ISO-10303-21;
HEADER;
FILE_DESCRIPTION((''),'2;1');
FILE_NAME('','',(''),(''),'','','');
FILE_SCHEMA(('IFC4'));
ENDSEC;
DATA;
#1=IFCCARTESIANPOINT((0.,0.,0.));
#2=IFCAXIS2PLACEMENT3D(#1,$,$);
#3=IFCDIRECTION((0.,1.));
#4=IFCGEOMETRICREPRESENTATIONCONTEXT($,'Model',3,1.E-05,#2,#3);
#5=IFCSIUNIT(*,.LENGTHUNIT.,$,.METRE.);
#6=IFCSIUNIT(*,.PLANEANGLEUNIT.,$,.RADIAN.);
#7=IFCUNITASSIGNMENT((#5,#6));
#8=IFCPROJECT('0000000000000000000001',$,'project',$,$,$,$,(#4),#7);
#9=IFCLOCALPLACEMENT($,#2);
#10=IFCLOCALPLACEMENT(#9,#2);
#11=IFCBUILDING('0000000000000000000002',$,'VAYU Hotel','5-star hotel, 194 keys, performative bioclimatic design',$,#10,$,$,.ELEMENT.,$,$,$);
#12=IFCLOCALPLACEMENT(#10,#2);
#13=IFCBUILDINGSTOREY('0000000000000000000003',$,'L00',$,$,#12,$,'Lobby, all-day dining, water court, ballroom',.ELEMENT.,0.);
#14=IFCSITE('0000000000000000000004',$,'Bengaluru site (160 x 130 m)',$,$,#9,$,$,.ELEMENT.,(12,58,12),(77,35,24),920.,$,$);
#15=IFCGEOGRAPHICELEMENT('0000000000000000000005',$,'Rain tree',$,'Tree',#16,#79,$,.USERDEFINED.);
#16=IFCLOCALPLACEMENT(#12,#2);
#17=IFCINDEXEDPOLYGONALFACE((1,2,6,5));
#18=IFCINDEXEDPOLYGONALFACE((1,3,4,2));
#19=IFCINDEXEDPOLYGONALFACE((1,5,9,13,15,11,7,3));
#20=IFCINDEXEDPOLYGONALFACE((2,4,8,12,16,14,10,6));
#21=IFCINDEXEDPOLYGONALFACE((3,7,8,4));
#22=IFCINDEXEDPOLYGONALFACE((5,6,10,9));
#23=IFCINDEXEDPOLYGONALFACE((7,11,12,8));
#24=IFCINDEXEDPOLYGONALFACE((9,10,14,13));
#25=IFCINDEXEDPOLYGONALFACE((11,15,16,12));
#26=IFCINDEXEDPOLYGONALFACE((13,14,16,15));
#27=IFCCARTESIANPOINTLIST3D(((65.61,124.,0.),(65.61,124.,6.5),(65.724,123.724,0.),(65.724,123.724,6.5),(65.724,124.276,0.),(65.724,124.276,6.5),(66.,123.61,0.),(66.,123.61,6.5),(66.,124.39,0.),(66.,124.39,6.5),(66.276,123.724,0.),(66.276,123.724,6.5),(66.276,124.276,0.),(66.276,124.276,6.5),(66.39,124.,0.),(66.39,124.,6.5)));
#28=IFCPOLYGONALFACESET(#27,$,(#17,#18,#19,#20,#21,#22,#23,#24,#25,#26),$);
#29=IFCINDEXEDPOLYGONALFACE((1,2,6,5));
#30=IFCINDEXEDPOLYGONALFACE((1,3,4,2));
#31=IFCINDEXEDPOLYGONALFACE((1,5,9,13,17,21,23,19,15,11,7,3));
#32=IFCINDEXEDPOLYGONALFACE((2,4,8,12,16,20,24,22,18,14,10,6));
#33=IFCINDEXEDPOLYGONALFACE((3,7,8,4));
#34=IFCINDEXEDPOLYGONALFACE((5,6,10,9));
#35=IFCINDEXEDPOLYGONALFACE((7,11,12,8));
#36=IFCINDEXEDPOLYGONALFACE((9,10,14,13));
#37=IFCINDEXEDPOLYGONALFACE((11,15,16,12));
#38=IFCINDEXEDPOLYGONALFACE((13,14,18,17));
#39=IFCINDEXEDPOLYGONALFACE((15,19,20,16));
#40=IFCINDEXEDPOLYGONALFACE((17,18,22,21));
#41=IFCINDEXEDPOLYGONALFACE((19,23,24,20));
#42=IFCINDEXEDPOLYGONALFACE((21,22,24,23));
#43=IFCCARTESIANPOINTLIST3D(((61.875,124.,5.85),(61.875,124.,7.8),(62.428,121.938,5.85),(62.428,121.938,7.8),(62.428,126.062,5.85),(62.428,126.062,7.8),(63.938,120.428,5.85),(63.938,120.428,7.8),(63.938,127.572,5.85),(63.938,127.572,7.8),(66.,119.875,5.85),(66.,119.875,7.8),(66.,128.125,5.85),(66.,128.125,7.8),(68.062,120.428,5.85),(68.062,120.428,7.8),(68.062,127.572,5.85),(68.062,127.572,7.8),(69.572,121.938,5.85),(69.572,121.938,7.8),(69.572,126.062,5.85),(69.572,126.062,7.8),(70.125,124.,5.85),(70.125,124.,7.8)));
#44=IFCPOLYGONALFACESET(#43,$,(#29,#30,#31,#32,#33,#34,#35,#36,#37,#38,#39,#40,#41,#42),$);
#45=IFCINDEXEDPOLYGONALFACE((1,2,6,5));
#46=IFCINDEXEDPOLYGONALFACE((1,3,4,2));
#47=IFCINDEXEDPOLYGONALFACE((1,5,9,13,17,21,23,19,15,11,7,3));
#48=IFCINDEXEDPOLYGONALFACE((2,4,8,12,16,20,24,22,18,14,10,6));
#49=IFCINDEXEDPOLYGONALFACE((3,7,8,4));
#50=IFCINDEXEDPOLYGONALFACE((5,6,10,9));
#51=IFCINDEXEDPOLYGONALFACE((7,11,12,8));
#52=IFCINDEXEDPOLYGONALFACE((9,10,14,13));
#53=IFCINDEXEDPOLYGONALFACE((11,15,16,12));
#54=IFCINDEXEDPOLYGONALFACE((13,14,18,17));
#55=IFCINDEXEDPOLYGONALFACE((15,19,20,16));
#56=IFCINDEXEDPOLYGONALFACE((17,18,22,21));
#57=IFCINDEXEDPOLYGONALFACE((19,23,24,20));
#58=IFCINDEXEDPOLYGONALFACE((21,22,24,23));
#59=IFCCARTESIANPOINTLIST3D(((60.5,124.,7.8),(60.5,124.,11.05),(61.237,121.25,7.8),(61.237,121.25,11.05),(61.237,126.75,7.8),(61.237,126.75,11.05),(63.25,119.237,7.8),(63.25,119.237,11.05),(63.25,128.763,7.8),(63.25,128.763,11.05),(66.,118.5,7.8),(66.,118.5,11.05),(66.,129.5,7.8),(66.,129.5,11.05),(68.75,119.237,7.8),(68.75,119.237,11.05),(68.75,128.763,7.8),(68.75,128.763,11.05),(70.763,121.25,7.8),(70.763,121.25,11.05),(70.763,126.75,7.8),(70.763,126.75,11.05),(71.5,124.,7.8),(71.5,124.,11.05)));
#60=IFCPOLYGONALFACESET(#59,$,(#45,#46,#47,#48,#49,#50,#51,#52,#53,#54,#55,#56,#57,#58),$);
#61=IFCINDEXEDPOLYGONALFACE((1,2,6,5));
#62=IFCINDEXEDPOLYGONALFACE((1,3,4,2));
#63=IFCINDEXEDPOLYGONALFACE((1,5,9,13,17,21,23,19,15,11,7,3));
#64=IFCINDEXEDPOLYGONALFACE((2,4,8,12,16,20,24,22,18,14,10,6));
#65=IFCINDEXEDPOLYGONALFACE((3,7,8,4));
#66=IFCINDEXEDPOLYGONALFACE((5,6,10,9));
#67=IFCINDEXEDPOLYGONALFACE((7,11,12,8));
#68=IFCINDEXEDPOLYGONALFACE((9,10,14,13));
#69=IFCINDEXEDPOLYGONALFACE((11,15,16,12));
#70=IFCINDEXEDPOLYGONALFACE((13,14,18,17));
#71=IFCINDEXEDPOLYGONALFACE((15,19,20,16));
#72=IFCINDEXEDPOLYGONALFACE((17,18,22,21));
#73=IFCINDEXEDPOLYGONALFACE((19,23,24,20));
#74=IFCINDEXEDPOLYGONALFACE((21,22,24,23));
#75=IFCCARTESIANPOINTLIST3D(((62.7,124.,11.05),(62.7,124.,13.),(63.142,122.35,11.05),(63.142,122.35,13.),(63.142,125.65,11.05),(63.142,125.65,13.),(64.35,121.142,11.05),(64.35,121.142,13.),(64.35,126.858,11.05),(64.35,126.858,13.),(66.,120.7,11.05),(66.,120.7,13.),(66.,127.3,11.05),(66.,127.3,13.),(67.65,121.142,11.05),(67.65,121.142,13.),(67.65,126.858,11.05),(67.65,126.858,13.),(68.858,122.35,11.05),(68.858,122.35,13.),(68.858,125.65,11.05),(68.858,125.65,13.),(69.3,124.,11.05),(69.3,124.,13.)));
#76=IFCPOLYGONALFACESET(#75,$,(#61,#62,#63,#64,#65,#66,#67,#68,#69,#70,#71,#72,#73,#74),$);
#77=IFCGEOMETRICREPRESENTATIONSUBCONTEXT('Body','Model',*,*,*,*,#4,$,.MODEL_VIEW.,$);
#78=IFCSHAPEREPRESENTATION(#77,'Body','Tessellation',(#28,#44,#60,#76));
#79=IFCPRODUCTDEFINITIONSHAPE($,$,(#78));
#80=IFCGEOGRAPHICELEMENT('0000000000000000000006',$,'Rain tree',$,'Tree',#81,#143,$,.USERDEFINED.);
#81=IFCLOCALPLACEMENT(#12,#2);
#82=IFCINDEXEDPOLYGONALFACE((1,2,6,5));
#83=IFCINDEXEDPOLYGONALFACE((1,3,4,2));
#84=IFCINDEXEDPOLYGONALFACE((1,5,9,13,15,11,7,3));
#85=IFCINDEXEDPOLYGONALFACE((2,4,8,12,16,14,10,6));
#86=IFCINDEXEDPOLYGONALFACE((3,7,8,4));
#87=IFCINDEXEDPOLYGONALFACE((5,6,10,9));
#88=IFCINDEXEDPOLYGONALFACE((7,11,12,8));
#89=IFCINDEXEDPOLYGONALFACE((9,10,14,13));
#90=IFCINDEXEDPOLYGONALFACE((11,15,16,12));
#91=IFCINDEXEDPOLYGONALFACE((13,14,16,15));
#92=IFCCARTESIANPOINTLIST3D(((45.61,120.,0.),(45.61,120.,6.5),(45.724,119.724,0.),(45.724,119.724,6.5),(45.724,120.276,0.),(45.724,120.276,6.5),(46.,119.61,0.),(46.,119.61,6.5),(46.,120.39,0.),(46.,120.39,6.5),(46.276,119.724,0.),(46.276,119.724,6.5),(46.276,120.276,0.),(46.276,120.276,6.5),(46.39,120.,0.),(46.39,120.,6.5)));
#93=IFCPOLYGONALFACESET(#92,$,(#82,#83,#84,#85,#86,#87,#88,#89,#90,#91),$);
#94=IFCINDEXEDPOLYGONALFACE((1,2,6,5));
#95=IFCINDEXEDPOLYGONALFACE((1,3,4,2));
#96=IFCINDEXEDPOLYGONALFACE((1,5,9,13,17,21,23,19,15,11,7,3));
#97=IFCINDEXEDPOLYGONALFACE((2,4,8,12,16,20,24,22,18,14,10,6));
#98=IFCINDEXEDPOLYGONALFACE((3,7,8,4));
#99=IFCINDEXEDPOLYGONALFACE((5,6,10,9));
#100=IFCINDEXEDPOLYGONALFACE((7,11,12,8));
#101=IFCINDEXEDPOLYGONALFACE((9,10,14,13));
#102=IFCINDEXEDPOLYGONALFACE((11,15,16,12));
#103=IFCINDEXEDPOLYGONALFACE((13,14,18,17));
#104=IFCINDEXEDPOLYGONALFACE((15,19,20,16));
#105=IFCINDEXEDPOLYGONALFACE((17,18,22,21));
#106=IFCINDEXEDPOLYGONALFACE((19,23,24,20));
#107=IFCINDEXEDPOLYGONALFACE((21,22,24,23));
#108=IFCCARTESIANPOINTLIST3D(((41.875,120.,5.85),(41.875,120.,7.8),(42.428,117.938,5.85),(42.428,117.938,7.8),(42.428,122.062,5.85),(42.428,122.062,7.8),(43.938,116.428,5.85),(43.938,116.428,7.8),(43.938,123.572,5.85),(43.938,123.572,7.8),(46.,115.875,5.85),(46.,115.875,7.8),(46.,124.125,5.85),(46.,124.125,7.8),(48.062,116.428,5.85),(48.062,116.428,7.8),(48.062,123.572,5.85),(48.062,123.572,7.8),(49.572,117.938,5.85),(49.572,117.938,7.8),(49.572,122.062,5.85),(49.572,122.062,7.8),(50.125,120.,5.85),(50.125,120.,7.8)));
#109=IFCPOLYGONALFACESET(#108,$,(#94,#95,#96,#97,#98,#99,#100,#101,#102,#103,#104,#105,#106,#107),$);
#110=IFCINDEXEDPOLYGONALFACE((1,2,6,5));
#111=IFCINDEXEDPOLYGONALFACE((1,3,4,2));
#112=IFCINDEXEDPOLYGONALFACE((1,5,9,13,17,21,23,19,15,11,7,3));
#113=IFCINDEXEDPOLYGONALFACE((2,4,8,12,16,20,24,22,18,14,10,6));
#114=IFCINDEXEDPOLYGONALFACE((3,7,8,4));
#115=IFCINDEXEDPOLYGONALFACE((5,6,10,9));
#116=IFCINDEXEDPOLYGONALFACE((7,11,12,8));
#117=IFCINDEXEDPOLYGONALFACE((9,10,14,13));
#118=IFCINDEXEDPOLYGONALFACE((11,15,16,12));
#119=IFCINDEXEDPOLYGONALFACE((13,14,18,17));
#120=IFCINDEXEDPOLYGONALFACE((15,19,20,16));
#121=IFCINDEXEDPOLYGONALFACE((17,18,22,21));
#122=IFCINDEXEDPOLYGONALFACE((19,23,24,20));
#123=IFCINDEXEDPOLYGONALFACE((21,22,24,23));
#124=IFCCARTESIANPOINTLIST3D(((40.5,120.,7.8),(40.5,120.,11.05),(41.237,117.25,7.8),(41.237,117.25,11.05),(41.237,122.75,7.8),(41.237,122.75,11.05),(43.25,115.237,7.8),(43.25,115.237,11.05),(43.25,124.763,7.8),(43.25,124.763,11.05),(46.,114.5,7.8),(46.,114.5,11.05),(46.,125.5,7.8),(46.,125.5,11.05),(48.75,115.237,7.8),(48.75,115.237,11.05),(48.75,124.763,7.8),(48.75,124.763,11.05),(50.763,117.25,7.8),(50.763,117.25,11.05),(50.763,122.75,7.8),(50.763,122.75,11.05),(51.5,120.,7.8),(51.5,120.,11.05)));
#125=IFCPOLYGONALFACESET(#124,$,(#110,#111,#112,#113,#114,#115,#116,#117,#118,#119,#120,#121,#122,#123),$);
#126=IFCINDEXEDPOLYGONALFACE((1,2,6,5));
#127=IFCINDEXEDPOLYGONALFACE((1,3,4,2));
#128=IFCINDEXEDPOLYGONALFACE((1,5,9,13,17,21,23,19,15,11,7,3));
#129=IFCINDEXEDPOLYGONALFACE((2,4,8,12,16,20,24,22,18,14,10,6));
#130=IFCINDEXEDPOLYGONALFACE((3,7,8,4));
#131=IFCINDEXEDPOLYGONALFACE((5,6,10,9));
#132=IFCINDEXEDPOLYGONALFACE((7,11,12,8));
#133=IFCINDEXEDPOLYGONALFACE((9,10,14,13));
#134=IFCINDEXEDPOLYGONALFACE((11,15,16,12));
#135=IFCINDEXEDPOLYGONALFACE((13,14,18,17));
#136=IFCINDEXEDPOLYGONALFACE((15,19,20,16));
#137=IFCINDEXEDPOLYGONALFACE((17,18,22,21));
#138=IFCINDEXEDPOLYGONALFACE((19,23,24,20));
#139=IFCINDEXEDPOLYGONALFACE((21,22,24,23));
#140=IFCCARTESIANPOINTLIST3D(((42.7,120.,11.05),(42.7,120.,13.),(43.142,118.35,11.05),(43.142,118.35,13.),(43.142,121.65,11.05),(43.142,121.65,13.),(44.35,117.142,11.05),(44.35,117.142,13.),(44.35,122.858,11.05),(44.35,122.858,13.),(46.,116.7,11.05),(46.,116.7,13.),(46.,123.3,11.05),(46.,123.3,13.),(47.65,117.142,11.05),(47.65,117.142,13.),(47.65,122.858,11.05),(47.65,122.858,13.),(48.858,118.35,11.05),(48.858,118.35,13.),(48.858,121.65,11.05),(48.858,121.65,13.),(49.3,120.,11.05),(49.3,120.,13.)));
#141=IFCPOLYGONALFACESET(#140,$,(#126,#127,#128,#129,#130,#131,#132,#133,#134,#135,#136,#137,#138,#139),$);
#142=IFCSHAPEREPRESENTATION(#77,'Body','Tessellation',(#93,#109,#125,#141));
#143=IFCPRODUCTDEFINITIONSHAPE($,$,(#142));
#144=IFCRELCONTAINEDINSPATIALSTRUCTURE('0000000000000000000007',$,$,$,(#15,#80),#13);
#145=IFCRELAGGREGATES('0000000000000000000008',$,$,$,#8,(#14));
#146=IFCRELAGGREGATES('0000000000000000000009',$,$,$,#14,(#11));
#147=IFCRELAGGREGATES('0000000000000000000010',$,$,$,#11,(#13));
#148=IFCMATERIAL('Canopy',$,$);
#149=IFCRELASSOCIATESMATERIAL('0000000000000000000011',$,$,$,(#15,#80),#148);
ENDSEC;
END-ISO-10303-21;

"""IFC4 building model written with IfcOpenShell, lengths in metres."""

from ifc_helpers import new_model, si_unit, direction, frame, origin, place, context, subcontext, project, spatial, polyline, outline, extrude, material, element, save


model = new_model("IFC4")

# Units and contexts
model_context = context("Model", 3, precision=1e-05, world=origin(), true_north=direction((0.0, 1.0)))
body_context = subcontext(model_context, "Body", "Model", "MODEL_VIEW")
ifc_project = project(units=[si_unit("LENGTHUNIT", "METRE"), si_unit("PLANEANGLEUNIT", "RADIAN")], contexts=[model_context])

# Site, building, storey
site_placement = place(None, origin())
site = spatial("IfcSite", under=ifc_project, at=site_placement, Name="Bengaluru site (160 x 130 m)", CompositionType="ELEMENT", RefLatitude=(12, 58, 12), RefLongitude=(77, 35, 24), RefElevation=920.0)
building_placement = place(site_placement, origin())
building = spatial("IfcBuilding", under=site, at=building_placement, Name="VAYU Hotel", Description="5-star hotel, 194 keys, performative bioclimatic design", CompositionType="ELEMENT")
storey_placement = place(building_placement, origin())
storey = spatial("IfcBuildingStorey", under=building, at=storey_placement, Name="L00", LongName="Lobby, all-day dining, water court, ballroom", CompositionType="ELEMENT", Elevation=0.0)

# Geographic elements
ifc_material_1 = material(Name="Canopy")
geographic_element_1_placement = place(storey_placement, origin())
element("IfcGeographicElement", 1, at=geographic_element_1_placement, inside=storey, material=ifc_material_1, Name="Rain tree", ObjectType="Tree", PredefinedType="USERDEFINED", context=body_context, shape_type="SweptSolid", body=[
    extrude(outline(polyline([(66.39, 124.0), (66.276, 124.276), (66.0, 124.39), (65.724, 124.276), (65.61, 124.0), (65.724, 123.724), (66.0, 123.61), (66.276, 123.724), (66.39, 124.0)])), origin(), (0.0, 0.0, 1.0), 6.5),
    extrude(outline(polyline([(70.125, 124.0), (69.572, 126.062), (68.062, 127.572), (66.0, 128.125), (63.938, 127.572), (62.428, 126.062), (61.875, 124.0), (62.428, 121.938), (63.938, 120.428), (66.0, 119.875), (68.062, 120.428), (69.572, 121.938), (70.125, 124.0)])), frame((0.0, 0.0, 5.85)), (0.0, 0.0, 1.0), 1.95),
    extrude(outline(polyline([(71.5, 124.0), (70.763, 126.75), (68.75, 128.763), (66.0, 129.5), (63.25, 128.763), (61.237, 126.75), (60.5, 124.0), (61.237, 121.25), (63.25, 119.237), (66.0, 118.5), (68.75, 119.237), (70.763, 121.25), (71.5, 124.0)])), frame((0.0, 0.0, 7.8)), (0.0, 0.0, 1.0), 3.25),
    extrude(outline(polyline([(69.3, 124.0), (68.858, 125.65), (67.65, 126.858), (66.0, 127.3), (64.35, 126.858), (63.142, 125.65), (62.7, 124.0), (63.142, 122.35), (64.35, 121.142), (66.0, 120.7), (67.65, 121.142), (68.858, 122.35), (69.3, 124.0)])), frame((0.0, 0.0, 11.05)), (0.0, 0.0, 1.0), 1.95),
])
geographic_element_2_placement = place(storey_placement, origin())
element("IfcGeographicElement", 2, at=geographic_element_2_placement, inside=storey, material=ifc_material_1, Name="Rain tree", ObjectType="Tree", PredefinedType="USERDEFINED", context=body_context, shape_type="SweptSolid", body=[
    extrude(outline(polyline([(46.39, 120.0), (46.276, 120.276), (46.0, 120.39), (45.724, 120.276), (45.61, 120.0), (45.724, 119.724), (46.0, 119.61), (46.276, 119.724), (46.39, 120.0)])), origin(), (0.0, 0.0, 1.0), 6.5),
    extrude(outline(polyline([(50.125, 120.0), (49.572, 122.062), (48.062, 123.572), (46.0, 124.125), (43.938, 123.572), (42.428, 122.062), (41.875, 120.0), (42.428, 117.938), (43.938, 116.428), (46.0, 115.875), (48.062, 116.428), (49.572, 117.938), (50.125, 120.0)])), frame((0.0, 0.0, 5.85)), (0.0, 0.0, 1.0), 1.95),
    extrude(outline(polyline([(51.5, 120.0), (50.763, 122.75), (48.75, 124.763), (46.0, 125.5), (43.25, 124.763), (41.237, 122.75), (40.5, 120.0), (41.237, 117.25), (43.25, 115.237), (46.0, 114.5), (48.75, 115.237), (50.763, 117.25), (51.5, 120.0)])), frame((0.0, 0.0, 7.8)), (0.0, 0.0, 1.0), 3.25),
    extrude(outline(polyline([(49.3, 120.0), (48.858, 121.65), (47.65, 122.858), (46.0, 123.3), (44.35, 122.858), (43.142, 121.65), (42.7, 120.0), (43.142, 118.35), (44.35, 117.142), (46.0, 116.7), (47.65, 117.142), (48.858, 118.35), (49.3, 120.0)])), frame((0.0, 0.0, 11.05)), (0.0, 0.0, 1.0), 1.95),
])

save(model, "model.ifc")
